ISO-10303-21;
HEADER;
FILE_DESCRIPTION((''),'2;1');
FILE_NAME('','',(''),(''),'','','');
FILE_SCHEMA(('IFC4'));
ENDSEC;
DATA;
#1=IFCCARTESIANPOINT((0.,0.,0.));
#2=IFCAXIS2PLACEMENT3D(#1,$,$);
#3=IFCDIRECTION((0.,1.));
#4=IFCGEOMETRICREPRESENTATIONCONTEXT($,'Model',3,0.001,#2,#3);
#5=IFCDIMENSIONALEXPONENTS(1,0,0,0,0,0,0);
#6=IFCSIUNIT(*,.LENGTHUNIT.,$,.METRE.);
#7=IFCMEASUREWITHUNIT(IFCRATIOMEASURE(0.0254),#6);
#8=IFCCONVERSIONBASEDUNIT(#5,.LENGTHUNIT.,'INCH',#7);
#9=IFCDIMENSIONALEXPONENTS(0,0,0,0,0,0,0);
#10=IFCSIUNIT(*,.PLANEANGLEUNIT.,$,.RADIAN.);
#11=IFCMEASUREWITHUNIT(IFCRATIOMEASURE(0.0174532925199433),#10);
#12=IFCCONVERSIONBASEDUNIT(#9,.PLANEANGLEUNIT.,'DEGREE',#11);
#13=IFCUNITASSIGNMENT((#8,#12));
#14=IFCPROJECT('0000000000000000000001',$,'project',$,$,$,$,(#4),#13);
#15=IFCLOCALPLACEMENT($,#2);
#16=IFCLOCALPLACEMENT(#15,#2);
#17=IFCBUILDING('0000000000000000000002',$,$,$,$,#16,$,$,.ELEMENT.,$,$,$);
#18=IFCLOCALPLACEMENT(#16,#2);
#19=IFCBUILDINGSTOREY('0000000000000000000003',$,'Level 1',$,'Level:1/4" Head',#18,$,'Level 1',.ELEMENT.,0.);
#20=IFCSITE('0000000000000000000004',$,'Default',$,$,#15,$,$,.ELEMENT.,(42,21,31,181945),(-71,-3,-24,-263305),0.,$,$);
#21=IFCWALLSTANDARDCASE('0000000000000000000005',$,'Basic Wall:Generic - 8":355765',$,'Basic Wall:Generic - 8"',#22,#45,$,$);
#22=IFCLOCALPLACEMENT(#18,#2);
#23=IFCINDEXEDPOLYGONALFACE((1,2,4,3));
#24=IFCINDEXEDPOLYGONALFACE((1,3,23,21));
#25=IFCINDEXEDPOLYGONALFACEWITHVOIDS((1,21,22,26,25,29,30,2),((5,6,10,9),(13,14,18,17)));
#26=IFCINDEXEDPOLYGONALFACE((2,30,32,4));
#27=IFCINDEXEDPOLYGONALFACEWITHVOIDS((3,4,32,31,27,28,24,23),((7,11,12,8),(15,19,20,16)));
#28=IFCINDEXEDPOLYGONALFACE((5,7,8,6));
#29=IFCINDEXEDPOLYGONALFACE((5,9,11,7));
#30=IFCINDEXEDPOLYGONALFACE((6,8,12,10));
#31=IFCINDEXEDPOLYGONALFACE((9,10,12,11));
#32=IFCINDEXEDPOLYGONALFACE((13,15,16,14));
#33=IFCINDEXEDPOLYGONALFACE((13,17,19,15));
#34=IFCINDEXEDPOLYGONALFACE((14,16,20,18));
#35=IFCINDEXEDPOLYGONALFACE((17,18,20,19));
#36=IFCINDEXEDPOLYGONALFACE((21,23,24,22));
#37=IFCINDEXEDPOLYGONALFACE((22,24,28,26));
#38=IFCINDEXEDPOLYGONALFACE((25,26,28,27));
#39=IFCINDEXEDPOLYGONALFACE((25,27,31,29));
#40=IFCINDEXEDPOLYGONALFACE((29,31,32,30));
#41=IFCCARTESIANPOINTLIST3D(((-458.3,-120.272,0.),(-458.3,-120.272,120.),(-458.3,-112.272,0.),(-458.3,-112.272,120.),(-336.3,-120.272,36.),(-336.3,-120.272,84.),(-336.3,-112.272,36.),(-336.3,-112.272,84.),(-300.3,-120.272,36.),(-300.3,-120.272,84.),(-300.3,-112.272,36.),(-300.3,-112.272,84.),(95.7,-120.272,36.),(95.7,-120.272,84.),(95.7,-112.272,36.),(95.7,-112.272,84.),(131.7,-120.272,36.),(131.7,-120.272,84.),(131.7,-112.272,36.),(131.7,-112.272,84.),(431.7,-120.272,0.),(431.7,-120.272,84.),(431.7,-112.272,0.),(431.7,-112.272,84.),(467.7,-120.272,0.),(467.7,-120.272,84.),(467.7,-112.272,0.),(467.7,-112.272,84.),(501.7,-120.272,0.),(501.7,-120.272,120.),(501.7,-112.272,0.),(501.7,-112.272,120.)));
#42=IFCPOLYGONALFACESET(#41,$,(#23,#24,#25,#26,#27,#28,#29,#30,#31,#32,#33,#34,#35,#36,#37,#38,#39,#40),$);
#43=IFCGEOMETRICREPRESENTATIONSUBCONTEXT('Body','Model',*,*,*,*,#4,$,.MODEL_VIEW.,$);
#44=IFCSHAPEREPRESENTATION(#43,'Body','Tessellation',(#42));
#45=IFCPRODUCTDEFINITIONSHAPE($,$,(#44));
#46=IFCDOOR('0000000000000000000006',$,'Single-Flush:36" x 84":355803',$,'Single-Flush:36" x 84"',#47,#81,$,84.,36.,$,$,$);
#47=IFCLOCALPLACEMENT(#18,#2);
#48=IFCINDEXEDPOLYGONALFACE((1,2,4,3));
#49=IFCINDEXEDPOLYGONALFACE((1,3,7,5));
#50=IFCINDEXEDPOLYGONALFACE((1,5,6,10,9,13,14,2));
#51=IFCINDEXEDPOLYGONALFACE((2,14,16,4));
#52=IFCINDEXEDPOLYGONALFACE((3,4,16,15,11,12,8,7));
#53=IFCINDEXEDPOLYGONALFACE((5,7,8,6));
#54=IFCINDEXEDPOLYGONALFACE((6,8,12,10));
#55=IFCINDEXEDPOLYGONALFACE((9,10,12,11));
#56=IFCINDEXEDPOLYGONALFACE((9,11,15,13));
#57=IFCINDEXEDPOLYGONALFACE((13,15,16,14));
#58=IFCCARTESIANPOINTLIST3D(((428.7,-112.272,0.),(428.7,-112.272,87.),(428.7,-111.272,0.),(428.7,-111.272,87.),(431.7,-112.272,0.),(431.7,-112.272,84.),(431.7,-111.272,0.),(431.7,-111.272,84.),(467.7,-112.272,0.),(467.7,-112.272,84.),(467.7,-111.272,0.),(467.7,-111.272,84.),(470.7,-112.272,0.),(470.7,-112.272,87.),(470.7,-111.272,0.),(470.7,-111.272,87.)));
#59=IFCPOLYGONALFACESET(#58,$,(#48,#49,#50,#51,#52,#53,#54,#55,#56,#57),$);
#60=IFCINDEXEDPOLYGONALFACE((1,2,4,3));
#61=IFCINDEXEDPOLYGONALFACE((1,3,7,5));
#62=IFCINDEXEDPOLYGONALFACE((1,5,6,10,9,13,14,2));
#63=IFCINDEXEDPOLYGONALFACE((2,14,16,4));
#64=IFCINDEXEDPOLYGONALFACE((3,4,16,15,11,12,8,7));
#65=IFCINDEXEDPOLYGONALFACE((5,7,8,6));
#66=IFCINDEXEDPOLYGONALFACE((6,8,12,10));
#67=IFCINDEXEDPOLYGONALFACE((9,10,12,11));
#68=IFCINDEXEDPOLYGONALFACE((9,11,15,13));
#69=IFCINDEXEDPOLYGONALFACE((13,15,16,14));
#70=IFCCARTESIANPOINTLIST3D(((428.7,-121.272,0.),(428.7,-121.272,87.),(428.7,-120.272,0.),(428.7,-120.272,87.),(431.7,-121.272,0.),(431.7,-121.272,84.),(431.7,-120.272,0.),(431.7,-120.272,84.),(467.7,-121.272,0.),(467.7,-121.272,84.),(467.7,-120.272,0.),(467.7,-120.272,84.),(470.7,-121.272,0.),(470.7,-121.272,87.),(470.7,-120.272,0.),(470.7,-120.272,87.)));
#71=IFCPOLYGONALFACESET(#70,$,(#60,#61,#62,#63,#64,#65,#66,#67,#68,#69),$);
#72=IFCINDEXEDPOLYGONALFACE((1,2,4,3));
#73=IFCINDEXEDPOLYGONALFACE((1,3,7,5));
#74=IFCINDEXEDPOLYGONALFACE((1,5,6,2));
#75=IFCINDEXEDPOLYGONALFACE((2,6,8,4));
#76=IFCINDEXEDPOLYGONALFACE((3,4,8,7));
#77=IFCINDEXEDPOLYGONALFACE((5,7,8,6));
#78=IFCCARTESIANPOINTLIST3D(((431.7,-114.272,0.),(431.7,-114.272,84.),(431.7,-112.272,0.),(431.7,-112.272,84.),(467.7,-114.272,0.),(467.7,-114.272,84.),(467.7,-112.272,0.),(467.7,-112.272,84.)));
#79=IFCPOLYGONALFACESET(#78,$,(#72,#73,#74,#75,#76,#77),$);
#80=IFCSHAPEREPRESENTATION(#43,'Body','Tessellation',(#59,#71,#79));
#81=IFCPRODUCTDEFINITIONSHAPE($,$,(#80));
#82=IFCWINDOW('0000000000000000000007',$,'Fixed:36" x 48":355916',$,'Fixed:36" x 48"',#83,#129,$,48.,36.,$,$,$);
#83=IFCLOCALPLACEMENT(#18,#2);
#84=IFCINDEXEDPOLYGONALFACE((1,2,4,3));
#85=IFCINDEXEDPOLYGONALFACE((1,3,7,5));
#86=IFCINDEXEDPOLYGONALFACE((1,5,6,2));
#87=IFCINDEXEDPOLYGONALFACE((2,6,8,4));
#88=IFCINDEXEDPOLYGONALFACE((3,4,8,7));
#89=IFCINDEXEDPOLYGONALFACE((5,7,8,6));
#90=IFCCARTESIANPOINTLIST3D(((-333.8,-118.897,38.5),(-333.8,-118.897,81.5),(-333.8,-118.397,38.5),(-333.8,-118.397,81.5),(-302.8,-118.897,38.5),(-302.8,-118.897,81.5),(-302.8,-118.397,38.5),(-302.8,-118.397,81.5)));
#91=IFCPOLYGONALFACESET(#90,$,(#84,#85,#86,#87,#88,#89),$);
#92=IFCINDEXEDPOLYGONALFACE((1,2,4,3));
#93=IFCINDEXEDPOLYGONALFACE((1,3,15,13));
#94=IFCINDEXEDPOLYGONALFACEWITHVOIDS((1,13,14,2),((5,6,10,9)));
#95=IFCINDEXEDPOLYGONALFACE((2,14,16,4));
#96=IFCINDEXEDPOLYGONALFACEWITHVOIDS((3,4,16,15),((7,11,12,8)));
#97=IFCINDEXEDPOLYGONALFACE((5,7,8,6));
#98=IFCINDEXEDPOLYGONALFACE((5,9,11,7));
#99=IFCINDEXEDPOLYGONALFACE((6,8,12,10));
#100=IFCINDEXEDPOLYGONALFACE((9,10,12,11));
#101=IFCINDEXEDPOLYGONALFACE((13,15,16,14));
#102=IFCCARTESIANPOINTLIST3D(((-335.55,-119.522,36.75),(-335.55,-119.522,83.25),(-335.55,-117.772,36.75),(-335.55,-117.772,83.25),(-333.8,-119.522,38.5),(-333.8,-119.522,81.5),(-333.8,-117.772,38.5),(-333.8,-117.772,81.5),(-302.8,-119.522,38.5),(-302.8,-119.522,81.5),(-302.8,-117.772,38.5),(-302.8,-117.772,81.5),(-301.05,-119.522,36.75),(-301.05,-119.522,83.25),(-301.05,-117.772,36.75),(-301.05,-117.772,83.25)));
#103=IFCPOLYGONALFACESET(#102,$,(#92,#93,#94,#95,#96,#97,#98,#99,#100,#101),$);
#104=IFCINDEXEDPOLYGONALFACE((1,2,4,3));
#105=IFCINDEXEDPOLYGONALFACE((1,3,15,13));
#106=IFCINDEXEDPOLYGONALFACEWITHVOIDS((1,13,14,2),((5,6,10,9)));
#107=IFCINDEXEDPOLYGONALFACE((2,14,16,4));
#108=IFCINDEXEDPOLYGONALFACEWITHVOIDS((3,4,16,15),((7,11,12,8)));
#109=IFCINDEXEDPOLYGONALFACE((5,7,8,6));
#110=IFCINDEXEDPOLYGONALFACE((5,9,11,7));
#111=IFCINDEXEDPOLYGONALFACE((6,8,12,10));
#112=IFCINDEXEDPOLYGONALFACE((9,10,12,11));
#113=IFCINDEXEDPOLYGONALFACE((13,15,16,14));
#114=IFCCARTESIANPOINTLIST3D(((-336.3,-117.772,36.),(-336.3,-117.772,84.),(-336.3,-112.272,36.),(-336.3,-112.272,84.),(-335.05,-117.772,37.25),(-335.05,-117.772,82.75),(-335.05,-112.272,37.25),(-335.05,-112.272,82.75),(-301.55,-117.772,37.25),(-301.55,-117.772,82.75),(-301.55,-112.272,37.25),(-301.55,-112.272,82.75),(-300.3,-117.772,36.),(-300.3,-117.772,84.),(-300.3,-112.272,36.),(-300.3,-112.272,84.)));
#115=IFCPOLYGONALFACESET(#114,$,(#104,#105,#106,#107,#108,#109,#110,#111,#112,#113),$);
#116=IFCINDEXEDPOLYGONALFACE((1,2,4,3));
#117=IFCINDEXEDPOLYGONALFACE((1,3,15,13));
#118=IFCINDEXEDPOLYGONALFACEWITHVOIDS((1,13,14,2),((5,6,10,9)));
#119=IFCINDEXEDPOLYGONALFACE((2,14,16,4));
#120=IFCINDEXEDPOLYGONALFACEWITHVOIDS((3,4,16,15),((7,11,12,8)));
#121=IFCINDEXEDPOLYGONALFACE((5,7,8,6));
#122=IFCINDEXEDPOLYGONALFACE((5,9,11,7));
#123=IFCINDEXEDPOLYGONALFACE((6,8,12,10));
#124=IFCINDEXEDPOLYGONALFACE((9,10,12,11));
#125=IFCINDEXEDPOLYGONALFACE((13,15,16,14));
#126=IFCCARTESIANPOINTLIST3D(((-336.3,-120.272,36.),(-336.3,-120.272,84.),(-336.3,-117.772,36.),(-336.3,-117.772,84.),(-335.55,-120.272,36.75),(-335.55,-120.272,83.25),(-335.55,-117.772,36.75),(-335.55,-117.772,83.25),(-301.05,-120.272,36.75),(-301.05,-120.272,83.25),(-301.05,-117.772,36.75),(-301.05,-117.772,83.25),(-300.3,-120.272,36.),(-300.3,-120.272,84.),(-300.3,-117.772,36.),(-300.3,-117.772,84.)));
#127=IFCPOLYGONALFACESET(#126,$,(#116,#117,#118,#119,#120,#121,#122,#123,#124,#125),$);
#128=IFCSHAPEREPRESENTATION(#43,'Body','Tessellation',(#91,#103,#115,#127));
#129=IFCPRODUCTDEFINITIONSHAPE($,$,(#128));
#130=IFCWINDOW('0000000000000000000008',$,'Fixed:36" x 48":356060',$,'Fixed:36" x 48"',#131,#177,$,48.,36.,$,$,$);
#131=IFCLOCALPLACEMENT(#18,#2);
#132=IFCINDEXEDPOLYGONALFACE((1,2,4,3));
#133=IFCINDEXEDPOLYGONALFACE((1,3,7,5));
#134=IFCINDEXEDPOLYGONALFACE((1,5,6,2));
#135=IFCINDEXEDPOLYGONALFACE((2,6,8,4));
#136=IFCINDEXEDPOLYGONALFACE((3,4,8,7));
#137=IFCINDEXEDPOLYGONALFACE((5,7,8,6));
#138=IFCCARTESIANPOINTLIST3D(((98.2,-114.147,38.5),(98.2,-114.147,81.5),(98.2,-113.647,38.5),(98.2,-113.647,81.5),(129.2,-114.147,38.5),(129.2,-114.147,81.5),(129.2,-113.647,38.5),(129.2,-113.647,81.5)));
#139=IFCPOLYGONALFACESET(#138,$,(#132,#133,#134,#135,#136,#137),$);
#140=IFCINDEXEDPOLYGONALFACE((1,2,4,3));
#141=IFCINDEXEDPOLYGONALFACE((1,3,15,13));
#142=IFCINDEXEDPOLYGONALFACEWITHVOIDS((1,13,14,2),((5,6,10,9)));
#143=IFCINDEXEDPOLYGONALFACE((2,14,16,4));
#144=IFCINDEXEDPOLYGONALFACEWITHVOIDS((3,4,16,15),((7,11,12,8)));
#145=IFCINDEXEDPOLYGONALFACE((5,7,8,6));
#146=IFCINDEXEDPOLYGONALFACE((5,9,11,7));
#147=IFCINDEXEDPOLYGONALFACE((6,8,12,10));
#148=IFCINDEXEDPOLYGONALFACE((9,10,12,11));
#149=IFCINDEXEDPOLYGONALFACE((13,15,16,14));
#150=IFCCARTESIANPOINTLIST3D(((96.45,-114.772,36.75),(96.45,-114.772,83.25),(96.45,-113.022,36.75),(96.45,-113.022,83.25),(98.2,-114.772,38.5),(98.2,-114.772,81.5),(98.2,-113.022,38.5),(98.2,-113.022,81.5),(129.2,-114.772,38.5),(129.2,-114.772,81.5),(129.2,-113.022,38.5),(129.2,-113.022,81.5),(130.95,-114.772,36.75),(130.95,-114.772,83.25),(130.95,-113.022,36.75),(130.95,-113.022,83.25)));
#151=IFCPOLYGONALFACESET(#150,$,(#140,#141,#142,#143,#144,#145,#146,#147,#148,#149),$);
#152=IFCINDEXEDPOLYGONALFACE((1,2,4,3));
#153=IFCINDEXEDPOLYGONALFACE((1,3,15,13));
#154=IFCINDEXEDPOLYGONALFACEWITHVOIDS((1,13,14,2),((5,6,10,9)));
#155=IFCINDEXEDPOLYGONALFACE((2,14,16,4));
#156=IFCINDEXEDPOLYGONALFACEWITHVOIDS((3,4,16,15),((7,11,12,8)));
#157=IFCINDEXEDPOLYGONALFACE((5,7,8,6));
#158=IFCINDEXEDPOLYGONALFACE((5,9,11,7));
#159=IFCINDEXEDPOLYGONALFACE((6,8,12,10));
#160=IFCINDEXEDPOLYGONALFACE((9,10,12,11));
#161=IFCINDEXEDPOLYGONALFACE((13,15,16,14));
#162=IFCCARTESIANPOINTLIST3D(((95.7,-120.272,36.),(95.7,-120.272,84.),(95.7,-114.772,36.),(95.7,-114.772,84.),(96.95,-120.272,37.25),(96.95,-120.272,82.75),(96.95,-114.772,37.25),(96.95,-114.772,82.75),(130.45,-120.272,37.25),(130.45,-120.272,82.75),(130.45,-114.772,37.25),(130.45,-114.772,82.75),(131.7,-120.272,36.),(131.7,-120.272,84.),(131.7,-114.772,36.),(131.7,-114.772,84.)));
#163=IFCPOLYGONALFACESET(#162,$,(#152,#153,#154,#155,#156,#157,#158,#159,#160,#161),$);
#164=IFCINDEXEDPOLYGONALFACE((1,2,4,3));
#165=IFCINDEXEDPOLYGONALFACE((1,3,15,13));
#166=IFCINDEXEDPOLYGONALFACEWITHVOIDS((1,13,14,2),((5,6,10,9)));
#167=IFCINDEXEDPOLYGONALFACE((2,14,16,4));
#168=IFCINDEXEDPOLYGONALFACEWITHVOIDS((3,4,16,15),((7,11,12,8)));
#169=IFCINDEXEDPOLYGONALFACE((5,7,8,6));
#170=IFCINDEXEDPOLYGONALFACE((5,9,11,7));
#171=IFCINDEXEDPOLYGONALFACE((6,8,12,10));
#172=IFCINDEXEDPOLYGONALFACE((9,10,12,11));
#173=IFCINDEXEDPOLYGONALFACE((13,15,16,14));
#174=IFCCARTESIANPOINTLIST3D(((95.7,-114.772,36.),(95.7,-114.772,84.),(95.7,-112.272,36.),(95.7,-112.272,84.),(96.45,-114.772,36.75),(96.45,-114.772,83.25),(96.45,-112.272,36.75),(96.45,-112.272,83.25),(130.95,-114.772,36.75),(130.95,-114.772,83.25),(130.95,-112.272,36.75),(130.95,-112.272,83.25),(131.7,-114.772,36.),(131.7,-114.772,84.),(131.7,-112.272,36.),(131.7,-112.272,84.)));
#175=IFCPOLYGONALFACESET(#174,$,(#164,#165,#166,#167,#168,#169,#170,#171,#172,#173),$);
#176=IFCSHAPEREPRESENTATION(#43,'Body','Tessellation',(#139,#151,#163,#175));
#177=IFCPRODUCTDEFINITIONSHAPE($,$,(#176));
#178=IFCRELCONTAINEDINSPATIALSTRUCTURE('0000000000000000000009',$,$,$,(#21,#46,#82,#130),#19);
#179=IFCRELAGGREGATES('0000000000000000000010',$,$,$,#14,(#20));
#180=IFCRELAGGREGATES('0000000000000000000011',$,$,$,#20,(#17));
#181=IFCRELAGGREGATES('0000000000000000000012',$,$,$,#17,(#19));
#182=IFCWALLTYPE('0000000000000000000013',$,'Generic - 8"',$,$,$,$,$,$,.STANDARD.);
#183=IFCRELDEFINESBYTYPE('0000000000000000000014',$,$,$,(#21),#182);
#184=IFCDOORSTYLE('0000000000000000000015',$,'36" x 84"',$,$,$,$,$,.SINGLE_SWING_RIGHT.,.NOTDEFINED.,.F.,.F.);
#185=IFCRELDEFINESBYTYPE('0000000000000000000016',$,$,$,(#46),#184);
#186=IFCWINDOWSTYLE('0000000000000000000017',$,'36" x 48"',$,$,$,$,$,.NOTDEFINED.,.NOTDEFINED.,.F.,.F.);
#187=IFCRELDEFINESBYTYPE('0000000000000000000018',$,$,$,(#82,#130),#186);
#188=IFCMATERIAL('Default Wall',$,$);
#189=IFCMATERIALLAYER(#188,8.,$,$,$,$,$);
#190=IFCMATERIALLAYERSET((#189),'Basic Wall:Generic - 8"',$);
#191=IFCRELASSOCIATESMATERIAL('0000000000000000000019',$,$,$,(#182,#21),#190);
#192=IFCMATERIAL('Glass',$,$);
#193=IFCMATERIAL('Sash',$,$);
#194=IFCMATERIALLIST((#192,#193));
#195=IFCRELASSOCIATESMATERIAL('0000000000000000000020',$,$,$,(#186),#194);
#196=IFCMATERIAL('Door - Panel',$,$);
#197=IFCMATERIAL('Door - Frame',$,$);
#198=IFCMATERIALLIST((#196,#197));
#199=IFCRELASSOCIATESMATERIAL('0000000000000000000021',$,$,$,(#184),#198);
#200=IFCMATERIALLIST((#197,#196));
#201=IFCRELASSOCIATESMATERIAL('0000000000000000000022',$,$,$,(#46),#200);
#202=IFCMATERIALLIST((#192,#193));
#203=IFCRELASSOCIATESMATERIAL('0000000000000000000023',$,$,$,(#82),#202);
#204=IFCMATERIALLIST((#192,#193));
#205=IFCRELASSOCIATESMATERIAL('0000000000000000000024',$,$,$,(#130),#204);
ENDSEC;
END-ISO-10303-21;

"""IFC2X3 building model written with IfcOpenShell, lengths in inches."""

from ifc_helpers import new_model, entity, si_unit, converted_unit, direction, frame, frame_2d, origin, place, context, subcontext, project, spatial, polyline, rectangle, outline, extrude, clip, halfspace, source, transform, mapped, material, material_list, layer, layer_set, layer_usage, type_object, type_shapes, element, fill, save


model = new_model("IFC2X3")

# Units and contexts
model_context = context("Model", 3, precision=0.001, world=origin(), true_north=direction((0.0, 1.0)))
body_context = subcontext(model_context, "Body", "Model", "MODEL_VIEW")
ifc_project = project(units=[converted_unit("LENGTHUNIT", "INCH", entity("IfcRatioMeasure", 0.0254), si_unit("LENGTHUNIT", "METRE"), dimensions=[1, 0, 0, 0, 0, 0, 0]), converted_unit("PLANEANGLEUNIT", "DEGREE", entity("IfcRatioMeasure", 0.0174532925199433), si_unit("PLANEANGLEUNIT", "RADIAN"), dimensions=[0, 0, 0, 0, 0, 0, 0])], contexts=[model_context])

# Site, building, storey
site_placement = place(None, origin())
site = spatial("IfcSite", under=ifc_project, at=site_placement, Name="Default", CompositionType="ELEMENT", RefLatitude=(42, 21, 31, 181945), RefLongitude=(-71, -3, -24, -263305), RefElevation=0.0)
building_placement = place(site_placement, origin())
building = spatial("IfcBuilding", under=site, at=building_placement, CompositionType="ELEMENT")
storey_placement = place(building_placement, origin())
storey = spatial("IfcBuildingStorey", under=building, at=storey_placement, Name="Level 1", ObjectType="Level:1/4\" Head", LongName="Level 1", CompositionType="ELEMENT", Elevation=0.0)

# Shared definitions
ifc_material_1 = material(Name="Default Wall")
ifc_layer = layer(ifc_material_1, 8.0)
ifc_layer_set = layer_set([ifc_layer], Name="Basic Wall:Generic - 8\"")
wall_type = type_object("IfcWallType", Name="Generic - 8\"", PredefinedType="STANDARD", material=ifc_layer_set)
ifc_material_2 = material(Name="Glass")
ifc_material_3 = material(Name="Sash")
ifc_material_list_1 = material_list([ifc_material_2, ifc_material_3])
window_style = type_object("IfcWindowStyle", Name="36\" x 48\"", ConstructionType="NOTDEFINED", OperationType="NOTDEFINED", ParameterTakesPrecedence=False, Sizeable=False, material=ifc_material_list_1)
shared_shape_1 = source(origin(), body_context, "Body", "SweptSolid", [
    extrude(rectangle(XDim=0.5, YDim=31.0, at=frame_2d((0.0, 0.0), x_axis=(1.0, 0.0))), frame((18.0, 6.375, 2.5), z_axis=(0.0, 0.0, 1.0), x_axis=(0.0, 1.0, 0.0)), (0.0, 0.0, 1.0), 43.0),
    extrude(outline(polyline([(-17.25, -23.25), (17.25, -23.25), (17.25, 23.25), (-17.25, 23.25), (-17.25, -23.25)]), holes=[polyline([(-15.5, -21.5), (-15.5, 21.5), (15.5, 21.5), (15.5, -21.5), (-15.5, -21.5)])]), frame((18.0, 5.5, 24.0), z_axis=(0.0, 1.0, 0.0), x_axis=(1.0, 0.0, 0.0)), (0.0, 0.0, 1.0), 1.75),
    extrude(outline(polyline([(-18.0, -24.0), (18.0, -24.0), (18.0, 24.0), (-18.0, 24.0), (-18.0, -24.0)]), holes=[polyline([(-16.75, -22.75), (-16.75, 22.75), (16.75, 22.75), (16.75, -22.75), (-16.75, -22.75)])]), frame((18.0, 0.0, 24.0), z_axis=(0.0, 1.0, 0.0), x_axis=(1.0, 0.0, 0.0)), (0.0, 0.0, 1.0), 5.5),
    extrude(outline(polyline([(-24.0, -18.0), (24.0, -18.0), (24.0, 18.0), (-24.0, 18.0), (-24.0, -18.0)]), holes=[polyline([(-23.25, -17.25), (-23.25, 17.25), (23.25, 17.25), (23.25, -17.25), (-23.25, -17.25)])]), frame((18.0, 5.5, 24.0), z_axis=(0.0, 1.0, 0.0), x_axis=(0.0, 0.0, -1.0)), (0.0, 0.0, 1.0), 2.5),
])
type_shapes(window_style, [shared_shape_1])

# Wall, openings, door, windows
ifc_layer_usage_1 = layer_usage(ifc_layer_set, "AXIS2", "NEGATIVE", 4.0)
wall_1_placement = place(storey_placement, frame((501.7, -116.272, 0.0), z_axis=(0.0, 0.0, 1.0), x_axis=(-1.0, 0.0, 0.0)))
wall_1 = element("IfcWallStandardCase", 1, at=wall_1_placement, inside=storey, type_object=wall_type, material=ifc_layer_usage_1, Name="Basic Wall:Generic - 8\":355765", ObjectType="Basic Wall:Generic - 8\"", context=body_context, shape_type="Clipping", body=[
    clip(extrude(rectangle(XDim=960.0, YDim=8.0, at=frame_2d((480.0, 0.0), x_axis=(-1.0, 0.0))), origin(), (0.0, 0.0, 1.0), 120.0), halfspace(origin(), True)),
])
opening_1_placement = place(wall_1_placement, frame((70.0, 4.0, 0.0)))
opening_1 = element("IfcOpeningElement", 2, at=opening_1_placement, cuts=wall_1, ObjectType="Opening", context=body_context, shape_type="SweptSolid", body=[
    extrude(rectangle(XDim=36.0, YDim=84.0, at=frame_2d((42.0, 18.0), x_axis=(0.0, 1.0))), frame((0.0, 0.0, 0.0), z_axis=(0.0, -1.0, 0.0), x_axis=(0.0, 0.0, 1.0)), (0.0, 0.0, 1.0), 8.0),
])
opening_2_placement = place(wall_1_placement, frame((802.0, -4.0, 36.0)))
opening_2 = element("IfcOpeningElement", 3, at=opening_2_placement, cuts=wall_1, ObjectType="Opening", context=body_context, shape_type="SweptSolid", body=[
    extrude(rectangle(XDim=48.0, YDim=36.0, at=frame_2d((24.0, 18.0), x_axis=(-1.0, 0.0))), frame((0.0, 0.0, 0.0), z_axis=(0.0, 1.0, 0.0), x_axis=(0.0, 0.0, 1.0)), (0.0, 0.0, 1.0), 8.0),
])
opening_3_placement = place(wall_1_placement, frame((406.0, 4.0, 36.0)))
opening_3 = element("IfcOpeningElement", 4, at=opening_3_placement, cuts=wall_1, ObjectType="Opening", context=body_context, shape_type="SweptSolid", body=[
    extrude(rectangle(XDim=48.0, YDim=36.0, at=frame_2d((24.0, 18.0), x_axis=(-1.0, 0.0))), frame((0.0, 0.0, 0.0), z_axis=(0.0, -1.0, 0.0), x_axis=(0.0, 0.0, 1.0)), (0.0, 0.0, 1.0), 8.0),
])
ifc_material_4 = material(Name="Door - Frame")
ifc_material_5 = material(Name="Door - Panel")
ifc_material_list_2 = material_list([ifc_material_4, ifc_material_5])
ifc_material_list_3 = material_list([ifc_material_5, ifc_material_4])
door_style = type_object("IfcDoorStyle", Name="36\" x 84\"", ConstructionType="NOTDEFINED", OperationType="SINGLE_SWING_RIGHT", ParameterTakesPrecedence=False, Sizeable=False, material=ifc_material_list_3)
shared_shape_2 = source(origin(), body_context, "Body", "SweptSolid", [
    extrude(outline(polyline([(-21.0, -44.25), (21.0, -44.25), (21.0, 42.75), (18.0, 42.75), (18.0, -41.25), (-18.0, -41.25), (-18.0, 42.75), (-21.0, 42.75), (-21.0, -44.25)])), frame((18.0, 8.0, 42.75), z_axis=(0.0, 1.0, 0.0), x_axis=(1.0, 0.0, 0.0)), (0.0, 0.0, 1.0), 1.0),
    extrude(outline(polyline([(-44.25, -21.0), (42.75, -21.0), (42.75, -18.0), (-41.25, -18.0), (-41.25, 18.0), (42.75, 18.0), (42.75, 21.0), (-44.25, 21.0), (-44.25, -21.0)])), frame((18.0, -1.0, 42.75), z_axis=(0.0, 1.0, 0.0), x_axis=(0.0, 0.0, -1.0)), (0.0, 0.0, 1.0), 1.0),
    extrude(rectangle(XDim=2.0, YDim=36.0, at=frame_2d((0.0, 0.0), x_axis=(1.0, 0.0))), frame((18.0, 7.0, 0.0), z_axis=(0.0, 0.0, 1.0), x_axis=(0.0, 1.0, 0.0)), (0.0, 0.0, 1.0), 84.0),
])
type_shapes(door_style, [shared_shape_2])
door_1_placement = place(opening_1_placement, frame((0.0, 0.0, 0.0), z_axis=(0.0, 0.0, 1.0), x_axis=(-1.0, 0.0, 0.0)))
door_1 = element("IfcDoor", 5, at=door_1_placement, inside=storey, type_object=door_style, material=ifc_material_list_2, Name="Single-Flush:36\" x 84\":355803", ObjectType="Single-Flush:36\" x 84\"", OverallHeight=84.0, OverallWidth=36.0, context=body_context, shape_type="MappedRepresentation", body=[
    mapped(shared_shape_2, transform((0.0, 0.0, 0.0), scale=1.0)),
])
fill(opening_1, door_1)
ifc_material_list_4 = material_list([ifc_material_2, ifc_material_3])
window_1_placement = place(opening_2_placement, origin())
window_1 = element("IfcWindow", 6, at=window_1_placement, inside=storey, type_object=window_style, material=ifc_material_list_4, Name="Fixed:36\" x 48\":355916", ObjectType="Fixed:36\" x 48\"", OverallHeight=48.0, OverallWidth=36.0, context=body_context, shape_type="MappedRepresentation", body=[
    mapped(shared_shape_1, transform((0.0, 0.0, 0.0), scale=1.0)),
])
fill(opening_2, window_1)
ifc_material_list_5 = material_list([ifc_material_2, ifc_material_3])
window_2_placement = place(opening_3_placement, frame((0.0, 0.0, 0.0), z_axis=(0.0, 0.0, 1.0), x_axis=(-1.0, 0.0, 0.0)))
window_2 = element("IfcWindow", 7, at=window_2_placement, inside=storey, type_object=window_style, material=ifc_material_list_5, Name="Fixed:36\" x 48\":356060", ObjectType="Fixed:36\" x 48\"", OverallHeight=48.0, OverallWidth=36.0, context=body_context, shape_type="MappedRepresentation", body=[
    mapped(shared_shape_1, transform((0.0, 0.0, 0.0), scale=1.0)),
])
fill(opening_3, window_2)

save(model, "model.ifc")
